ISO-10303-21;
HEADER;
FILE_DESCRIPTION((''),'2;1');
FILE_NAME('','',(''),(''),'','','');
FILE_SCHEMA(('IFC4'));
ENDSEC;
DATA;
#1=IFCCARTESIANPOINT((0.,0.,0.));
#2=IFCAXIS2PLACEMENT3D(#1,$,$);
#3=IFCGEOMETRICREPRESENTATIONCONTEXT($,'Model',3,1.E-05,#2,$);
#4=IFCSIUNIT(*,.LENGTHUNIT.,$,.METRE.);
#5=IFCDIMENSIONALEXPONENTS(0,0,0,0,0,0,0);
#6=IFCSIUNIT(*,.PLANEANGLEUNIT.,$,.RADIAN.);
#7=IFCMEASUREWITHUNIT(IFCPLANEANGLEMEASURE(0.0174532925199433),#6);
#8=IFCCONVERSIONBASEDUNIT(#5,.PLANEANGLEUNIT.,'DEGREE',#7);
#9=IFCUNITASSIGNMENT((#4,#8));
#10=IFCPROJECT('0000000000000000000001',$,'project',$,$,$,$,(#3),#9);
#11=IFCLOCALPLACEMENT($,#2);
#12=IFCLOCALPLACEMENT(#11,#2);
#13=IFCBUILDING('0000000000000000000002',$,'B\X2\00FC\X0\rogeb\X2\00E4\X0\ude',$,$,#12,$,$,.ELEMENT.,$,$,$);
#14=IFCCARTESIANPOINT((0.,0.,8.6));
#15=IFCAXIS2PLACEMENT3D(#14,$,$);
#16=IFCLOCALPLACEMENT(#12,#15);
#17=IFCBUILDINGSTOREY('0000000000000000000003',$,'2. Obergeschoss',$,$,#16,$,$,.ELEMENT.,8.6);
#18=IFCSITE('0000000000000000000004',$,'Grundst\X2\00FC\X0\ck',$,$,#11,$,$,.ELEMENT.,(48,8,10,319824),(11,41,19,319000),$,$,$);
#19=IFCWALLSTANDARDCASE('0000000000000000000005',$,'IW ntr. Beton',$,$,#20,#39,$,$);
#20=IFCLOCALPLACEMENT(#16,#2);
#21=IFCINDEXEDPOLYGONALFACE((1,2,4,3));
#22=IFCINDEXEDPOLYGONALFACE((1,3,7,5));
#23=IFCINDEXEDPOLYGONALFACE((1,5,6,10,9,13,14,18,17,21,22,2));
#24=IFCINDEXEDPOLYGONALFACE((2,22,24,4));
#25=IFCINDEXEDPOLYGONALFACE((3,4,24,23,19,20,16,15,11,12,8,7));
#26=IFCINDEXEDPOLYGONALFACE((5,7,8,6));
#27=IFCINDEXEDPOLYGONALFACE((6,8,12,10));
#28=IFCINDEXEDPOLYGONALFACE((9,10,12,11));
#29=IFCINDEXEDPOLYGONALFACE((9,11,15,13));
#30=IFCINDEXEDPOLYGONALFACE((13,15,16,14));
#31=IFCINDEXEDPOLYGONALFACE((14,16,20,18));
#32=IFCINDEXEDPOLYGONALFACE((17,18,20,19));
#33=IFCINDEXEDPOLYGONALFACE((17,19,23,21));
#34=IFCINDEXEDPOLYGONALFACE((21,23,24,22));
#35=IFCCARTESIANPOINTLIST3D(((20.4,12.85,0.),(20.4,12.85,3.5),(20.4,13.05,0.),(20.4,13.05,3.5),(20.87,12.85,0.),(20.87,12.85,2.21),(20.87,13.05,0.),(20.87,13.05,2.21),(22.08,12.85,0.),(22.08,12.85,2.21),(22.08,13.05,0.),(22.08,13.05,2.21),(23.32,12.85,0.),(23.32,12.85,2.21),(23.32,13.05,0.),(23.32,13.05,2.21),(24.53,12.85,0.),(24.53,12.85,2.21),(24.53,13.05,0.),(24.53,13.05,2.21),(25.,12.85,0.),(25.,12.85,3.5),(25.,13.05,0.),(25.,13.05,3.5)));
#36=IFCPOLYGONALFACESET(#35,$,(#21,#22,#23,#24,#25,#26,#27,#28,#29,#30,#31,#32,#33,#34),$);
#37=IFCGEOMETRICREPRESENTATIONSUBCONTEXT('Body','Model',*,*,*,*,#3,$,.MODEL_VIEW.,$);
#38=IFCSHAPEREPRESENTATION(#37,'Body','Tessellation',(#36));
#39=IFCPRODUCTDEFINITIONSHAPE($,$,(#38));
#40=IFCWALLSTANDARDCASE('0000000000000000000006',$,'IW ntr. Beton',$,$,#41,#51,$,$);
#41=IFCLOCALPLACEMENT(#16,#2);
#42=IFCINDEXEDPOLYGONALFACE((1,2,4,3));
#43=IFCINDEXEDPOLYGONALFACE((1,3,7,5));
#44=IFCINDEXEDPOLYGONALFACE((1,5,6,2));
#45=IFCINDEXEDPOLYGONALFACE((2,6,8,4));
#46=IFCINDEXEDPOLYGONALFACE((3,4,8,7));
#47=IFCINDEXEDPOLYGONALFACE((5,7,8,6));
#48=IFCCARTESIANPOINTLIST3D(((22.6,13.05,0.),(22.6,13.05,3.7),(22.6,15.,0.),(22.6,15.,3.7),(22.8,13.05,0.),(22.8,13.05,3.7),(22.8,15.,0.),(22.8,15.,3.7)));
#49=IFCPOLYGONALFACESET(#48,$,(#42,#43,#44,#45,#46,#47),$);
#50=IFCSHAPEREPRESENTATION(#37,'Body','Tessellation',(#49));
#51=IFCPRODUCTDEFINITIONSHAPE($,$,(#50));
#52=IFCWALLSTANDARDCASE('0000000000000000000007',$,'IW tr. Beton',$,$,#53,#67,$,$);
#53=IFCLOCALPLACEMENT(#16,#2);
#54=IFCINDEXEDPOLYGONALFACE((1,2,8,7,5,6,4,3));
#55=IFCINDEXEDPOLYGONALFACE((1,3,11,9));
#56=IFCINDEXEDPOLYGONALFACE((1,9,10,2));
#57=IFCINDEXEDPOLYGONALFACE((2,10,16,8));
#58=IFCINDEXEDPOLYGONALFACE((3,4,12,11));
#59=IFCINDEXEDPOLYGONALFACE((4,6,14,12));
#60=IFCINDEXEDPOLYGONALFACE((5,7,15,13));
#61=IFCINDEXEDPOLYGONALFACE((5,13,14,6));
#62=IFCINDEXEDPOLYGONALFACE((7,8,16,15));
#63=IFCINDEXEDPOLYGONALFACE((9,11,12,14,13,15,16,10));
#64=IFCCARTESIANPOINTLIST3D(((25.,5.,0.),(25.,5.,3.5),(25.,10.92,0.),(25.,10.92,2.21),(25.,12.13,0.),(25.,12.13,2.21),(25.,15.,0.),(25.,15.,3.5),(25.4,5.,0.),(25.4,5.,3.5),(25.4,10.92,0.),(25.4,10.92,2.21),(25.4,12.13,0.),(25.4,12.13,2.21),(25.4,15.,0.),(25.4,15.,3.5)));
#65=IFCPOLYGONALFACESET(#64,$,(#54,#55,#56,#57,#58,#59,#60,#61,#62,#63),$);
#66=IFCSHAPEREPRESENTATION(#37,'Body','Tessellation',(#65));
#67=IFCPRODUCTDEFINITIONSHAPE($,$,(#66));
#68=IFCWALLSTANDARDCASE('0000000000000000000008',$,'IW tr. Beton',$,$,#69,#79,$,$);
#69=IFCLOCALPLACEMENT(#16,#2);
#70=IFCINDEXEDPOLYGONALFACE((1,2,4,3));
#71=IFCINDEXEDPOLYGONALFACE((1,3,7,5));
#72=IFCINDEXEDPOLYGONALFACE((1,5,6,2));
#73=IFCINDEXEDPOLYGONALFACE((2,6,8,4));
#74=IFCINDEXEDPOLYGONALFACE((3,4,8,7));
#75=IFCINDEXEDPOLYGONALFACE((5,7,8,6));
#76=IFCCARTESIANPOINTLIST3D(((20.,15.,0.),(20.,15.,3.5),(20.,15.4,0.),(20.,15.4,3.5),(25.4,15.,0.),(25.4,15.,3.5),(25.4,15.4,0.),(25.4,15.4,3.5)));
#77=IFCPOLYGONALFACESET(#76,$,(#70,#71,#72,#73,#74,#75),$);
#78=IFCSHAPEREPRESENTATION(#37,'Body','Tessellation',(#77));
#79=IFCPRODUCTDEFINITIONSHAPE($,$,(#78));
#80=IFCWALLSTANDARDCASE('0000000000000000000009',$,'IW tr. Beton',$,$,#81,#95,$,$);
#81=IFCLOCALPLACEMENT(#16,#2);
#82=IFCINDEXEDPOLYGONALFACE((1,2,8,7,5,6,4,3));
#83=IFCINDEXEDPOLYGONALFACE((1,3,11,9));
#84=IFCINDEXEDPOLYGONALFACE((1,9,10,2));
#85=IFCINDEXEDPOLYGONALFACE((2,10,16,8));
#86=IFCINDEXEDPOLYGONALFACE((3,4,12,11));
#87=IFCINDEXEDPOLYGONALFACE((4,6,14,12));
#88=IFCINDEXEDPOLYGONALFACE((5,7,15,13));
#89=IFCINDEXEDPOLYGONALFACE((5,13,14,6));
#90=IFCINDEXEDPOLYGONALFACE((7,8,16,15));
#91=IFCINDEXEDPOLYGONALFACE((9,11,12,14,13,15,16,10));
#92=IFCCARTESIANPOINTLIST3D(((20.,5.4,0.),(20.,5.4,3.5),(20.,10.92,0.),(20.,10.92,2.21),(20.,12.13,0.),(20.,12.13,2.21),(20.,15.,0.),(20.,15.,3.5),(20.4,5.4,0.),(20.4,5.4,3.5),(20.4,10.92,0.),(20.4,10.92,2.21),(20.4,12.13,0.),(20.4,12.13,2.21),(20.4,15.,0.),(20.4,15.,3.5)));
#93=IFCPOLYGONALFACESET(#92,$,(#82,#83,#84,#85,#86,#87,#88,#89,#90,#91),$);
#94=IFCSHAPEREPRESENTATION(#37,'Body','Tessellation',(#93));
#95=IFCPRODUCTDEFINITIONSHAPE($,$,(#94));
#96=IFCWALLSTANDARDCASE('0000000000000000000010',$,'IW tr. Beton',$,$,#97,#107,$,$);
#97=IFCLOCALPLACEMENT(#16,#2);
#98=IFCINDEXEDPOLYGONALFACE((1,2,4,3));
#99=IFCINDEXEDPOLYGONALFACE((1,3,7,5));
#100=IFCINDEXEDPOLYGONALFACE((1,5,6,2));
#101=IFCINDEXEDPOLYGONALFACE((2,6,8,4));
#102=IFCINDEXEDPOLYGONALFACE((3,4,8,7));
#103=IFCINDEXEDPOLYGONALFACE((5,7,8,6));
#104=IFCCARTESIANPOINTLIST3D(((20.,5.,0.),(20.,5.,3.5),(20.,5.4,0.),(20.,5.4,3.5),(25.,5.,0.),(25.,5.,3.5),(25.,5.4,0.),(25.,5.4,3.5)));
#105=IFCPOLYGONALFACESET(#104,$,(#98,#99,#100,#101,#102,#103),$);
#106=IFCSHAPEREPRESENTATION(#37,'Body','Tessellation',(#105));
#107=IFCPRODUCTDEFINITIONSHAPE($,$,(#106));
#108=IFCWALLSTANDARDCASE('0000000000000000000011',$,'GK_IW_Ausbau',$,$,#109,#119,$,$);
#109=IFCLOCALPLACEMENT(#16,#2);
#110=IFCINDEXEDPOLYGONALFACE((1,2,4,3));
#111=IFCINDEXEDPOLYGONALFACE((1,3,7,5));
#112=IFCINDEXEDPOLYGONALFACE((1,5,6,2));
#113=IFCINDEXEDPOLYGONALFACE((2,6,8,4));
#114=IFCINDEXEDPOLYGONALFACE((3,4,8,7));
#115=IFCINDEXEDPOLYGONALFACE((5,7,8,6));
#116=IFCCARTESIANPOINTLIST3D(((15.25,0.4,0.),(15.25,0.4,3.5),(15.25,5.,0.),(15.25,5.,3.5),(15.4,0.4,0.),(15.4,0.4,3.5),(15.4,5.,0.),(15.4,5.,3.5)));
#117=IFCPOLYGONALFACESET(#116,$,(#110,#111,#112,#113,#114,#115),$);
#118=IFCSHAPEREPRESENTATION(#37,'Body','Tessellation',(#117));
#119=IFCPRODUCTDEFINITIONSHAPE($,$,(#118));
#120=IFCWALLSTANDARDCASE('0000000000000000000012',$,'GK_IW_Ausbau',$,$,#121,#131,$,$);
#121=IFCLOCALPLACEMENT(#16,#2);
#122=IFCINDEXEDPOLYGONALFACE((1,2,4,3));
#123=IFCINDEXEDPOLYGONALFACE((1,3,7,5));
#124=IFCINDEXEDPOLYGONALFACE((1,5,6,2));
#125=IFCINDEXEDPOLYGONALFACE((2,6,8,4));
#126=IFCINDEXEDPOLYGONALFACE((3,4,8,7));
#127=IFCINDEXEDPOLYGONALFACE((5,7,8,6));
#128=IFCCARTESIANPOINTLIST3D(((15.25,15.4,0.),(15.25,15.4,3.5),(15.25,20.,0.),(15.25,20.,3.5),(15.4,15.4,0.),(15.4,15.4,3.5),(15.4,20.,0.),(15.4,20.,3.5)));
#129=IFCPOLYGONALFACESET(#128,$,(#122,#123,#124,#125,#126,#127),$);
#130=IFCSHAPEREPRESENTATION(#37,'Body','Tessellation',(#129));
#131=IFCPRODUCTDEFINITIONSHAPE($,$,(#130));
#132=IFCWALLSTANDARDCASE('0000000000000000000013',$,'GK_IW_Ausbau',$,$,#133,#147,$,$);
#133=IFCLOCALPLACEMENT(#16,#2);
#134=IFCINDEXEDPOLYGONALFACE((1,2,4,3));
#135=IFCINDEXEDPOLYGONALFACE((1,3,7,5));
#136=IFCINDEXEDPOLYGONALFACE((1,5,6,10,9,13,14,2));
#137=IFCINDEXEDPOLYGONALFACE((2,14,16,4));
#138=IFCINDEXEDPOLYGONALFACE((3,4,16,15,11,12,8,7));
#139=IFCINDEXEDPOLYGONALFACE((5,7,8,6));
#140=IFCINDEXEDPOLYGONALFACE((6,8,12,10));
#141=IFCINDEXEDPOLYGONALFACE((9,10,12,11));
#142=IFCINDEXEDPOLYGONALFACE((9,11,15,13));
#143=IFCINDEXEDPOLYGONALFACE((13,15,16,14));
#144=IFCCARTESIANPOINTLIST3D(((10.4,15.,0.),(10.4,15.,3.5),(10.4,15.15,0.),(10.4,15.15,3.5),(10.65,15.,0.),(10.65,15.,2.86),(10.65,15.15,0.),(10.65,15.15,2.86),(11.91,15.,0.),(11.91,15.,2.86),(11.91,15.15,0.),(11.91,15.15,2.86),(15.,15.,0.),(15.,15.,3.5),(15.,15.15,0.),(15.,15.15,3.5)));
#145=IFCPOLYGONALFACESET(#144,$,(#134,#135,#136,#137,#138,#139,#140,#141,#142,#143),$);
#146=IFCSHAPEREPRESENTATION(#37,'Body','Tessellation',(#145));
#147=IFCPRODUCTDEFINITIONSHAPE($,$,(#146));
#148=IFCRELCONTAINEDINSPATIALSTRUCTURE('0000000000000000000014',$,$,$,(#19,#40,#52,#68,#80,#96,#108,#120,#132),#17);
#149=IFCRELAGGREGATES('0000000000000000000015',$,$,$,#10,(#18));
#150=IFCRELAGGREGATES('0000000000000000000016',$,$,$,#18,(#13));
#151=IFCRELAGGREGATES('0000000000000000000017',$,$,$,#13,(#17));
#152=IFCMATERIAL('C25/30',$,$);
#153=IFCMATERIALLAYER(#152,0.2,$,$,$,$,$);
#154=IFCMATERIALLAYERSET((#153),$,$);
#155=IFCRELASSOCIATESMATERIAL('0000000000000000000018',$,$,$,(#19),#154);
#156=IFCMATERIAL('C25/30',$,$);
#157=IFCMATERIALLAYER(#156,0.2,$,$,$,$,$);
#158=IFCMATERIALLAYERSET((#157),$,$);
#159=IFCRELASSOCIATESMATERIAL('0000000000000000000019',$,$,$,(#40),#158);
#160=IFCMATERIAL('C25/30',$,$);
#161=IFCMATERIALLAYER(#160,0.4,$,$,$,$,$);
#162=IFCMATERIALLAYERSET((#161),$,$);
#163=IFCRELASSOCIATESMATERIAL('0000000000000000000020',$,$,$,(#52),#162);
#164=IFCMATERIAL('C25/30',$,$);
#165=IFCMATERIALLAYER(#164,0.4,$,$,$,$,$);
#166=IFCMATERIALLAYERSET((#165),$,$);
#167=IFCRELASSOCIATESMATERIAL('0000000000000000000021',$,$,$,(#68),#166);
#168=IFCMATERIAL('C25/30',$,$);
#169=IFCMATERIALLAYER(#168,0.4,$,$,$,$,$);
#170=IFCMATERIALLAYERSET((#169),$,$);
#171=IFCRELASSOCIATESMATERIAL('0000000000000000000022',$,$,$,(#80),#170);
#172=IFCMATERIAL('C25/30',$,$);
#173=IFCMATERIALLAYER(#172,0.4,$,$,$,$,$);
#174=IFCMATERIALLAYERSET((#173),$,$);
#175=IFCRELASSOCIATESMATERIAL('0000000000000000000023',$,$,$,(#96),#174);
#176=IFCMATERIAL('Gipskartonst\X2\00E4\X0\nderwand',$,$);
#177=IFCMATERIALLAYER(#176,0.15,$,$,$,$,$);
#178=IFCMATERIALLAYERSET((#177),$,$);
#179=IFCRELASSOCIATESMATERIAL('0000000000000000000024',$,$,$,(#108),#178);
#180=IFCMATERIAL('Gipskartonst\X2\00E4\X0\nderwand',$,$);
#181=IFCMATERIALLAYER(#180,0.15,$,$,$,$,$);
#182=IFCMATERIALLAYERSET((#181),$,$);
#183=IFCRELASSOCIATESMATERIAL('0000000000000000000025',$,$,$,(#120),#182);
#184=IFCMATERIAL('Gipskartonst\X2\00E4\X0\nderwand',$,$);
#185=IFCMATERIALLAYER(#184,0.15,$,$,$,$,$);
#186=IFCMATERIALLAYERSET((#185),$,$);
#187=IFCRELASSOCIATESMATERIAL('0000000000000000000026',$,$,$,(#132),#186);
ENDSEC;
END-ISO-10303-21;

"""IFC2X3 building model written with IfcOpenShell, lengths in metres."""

from ifc_helpers import new_model, entity, si_unit, converted_unit, frame, frame_2d, origin, origin_with_axes, place, context, subcontext, project, spatial, polyline, rectangle, outline, extrude, material, layer, layer_set, layer_usage, element, save


model = new_model("IFC2X3")

# Units and contexts
model_context = context("Model", 3, precision=1e-05, world=origin())
body_context = subcontext(model_context, "Body", "Model", "MODEL_VIEW")
ifc_project = project(units=[si_unit("LENGTHUNIT", "METRE"), converted_unit("PLANEANGLEUNIT", "DEGREE", entity("IfcPlaneAngleMeasure", 0.0174532925199433), si_unit("PLANEANGLEUNIT", "RADIAN"), dimensions=[0, 0, 0, 0, 0, 0, 0])], contexts=[model_context])

# Site, building, storey
site_placement = place(None, origin())
site = spatial("IfcSite", under=ifc_project, at=site_placement, Name="Grundstück", CompositionType="ELEMENT", RefLatitude=(48, 8, 10, 319824), RefLongitude=(11, 41, 19, 319000))
building_placement = place(site_placement, origin())
building = spatial("IfcBuilding", under=site, at=building_placement, Name="Bürogebäude", CompositionType="ELEMENT")
storey_placement = place(building_placement, frame((0.0, 0.0, 8.6)))
storey = spatial("IfcBuildingStorey", under=building, at=storey_placement, Name="2. Obergeschoss", CompositionType="ELEMENT", Elevation=8.6)

# Wall, openings
ifc_material_1 = material(Name="C25/30")
ifc_layer_1 = layer(ifc_material_1, 0.2)
ifc_layer_set_1 = layer_set([ifc_layer_1])
ifc_layer_usage_1 = layer_usage(ifc_layer_set_1, "AXIS2", "POSITIVE", -0.2)
wall_1_placement = place(storey_placement, frame((25.0, 13.05, 0.0), z_axis=(0.0, 0.0, 1.0), x_axis=(-1.0, 0.0, 0.0)))
wall_1 = element("IfcWallStandardCase", 1, at=wall_1_placement, inside=storey, material=ifc_layer_usage_1, Name="IW ntr. Beton", context=body_context, shape_type="SweptSolid", body=[
    extrude(rectangle(XDim=4.6, YDim=0.2, at=frame_2d((2.3, 0.1), x_axis=(1.0, 0.0))), origin_with_axes(), (0.0, 0.0, 1.0), 3.5),
])
opening_1_placement = place(wall_1_placement, frame((1.68, 0.2, 0.0), z_axis=(0.0, -1.0, 0.0), x_axis=(0.0, 0.0, 1.0)))
element("IfcOpeningElement", 2, at=opening_1_placement, cuts=wall_1, ObjectType="Opening", context=body_context, shape_type="SweptSolid", body=[
    extrude(outline(polyline([(0.0, 1.21), (2.21, 1.21), (2.21, 0.0), (0.0, 0.0), (0.0, 1.21)])), origin_with_axes(), (0.0, 0.0, 1.0), 0.2),
])
opening_2_placement = place(wall_1_placement, frame((4.13, 0.2, 0.0), z_axis=(0.0, -1.0, 0.0), x_axis=(0.0, 0.0, 1.0)))
element("IfcOpeningElement", 3, at=opening_2_placement, cuts=wall_1, ObjectType="Opening", context=body_context, shape_type="SweptSolid", body=[
    extrude(outline(polyline([(0.0, 1.21), (2.21, 1.21), (2.21, 0.0), (0.0, 0.0), (0.0, 1.21)])), origin_with_axes(), (0.0, 0.0, 1.0), 0.2),
])

# Wall
ifc_material_2 = material(Name="C25/30")
ifc_layer_2 = layer(ifc_material_2, 0.2)
ifc_layer_set_2 = layer_set([ifc_layer_2])
ifc_layer_usage_2 = layer_usage(ifc_layer_set_2, "AXIS2", "POSITIVE", -0.2)
wall_2_placement = place(storey_placement, frame((22.6, 15.0, 0.0), z_axis=(0.0, 0.0, 1.0), x_axis=(0.0, -1.0, 0.0)))
element("IfcWallStandardCase", 4, at=wall_2_placement, inside=storey, material=ifc_layer_usage_2, Name="IW ntr. Beton", context=body_context, shape_type="SweptSolid", body=[
    extrude(rectangle(XDim=1.95, YDim=0.2, at=frame_2d((0.975, 0.1), x_axis=(1.0, 0.0))), origin_with_axes(), (0.0, 0.0, 1.0), 3.7),
])

# Wall, opening
ifc_material_3 = material(Name="C25/30")
ifc_layer_3 = layer(ifc_material_3, 0.4)
ifc_layer_set_3 = layer_set([ifc_layer_3])
ifc_layer_usage_3 = layer_usage(ifc_layer_set_3, "AXIS2", "POSITIVE", -0.2)
wall_3_placement = place(storey_placement, frame((25.0, 15.0, 0.0), z_axis=(0.0, 0.0, 1.0), x_axis=(0.0, -1.0, 0.0)))
wall_3 = element("IfcWallStandardCase", 5, at=wall_3_placement, inside=storey, material=ifc_layer_usage_3, Name="IW tr. Beton", context=body_context, shape_type="SweptSolid", body=[
    extrude(rectangle(XDim=10.0, YDim=0.4, at=frame_2d((5.0, 0.2), x_axis=(1.0, 0.0))), origin_with_axes(), (0.0, 0.0, 1.0), 3.5),
])
opening_3_placement = place(wall_3_placement, frame((2.87, 0.0, 0.0), z_axis=(0.0, 1.0, 0.0), x_axis=(0.0, 0.0, 1.0)))
element("IfcOpeningElement", 6, at=opening_3_placement, cuts=wall_3, ObjectType="Opening", context=body_context, shape_type="SweptSolid", body=[
    extrude(outline(polyline([(0.0, 1.21), (2.21, 1.21), (2.21, 0.0), (0.0, 0.0), (0.0, 1.21)])), origin_with_axes(), (0.0, 0.0, 1.0), 0.4),
])

# Wall
ifc_material_4 = material(Name="C25/30")
ifc_layer_4 = layer(ifc_material_4, 0.4)
ifc_layer_set_4 = layer_set([ifc_layer_4])
ifc_layer_usage_4 = layer_usage(ifc_layer_set_4, "AXIS2", "POSITIVE", -0.2)
wall_4_placement = place(storey_placement, frame((20.0, 15.0, 0.0)))
element("IfcWallStandardCase", 7, at=wall_4_placement, inside=storey, material=ifc_layer_usage_4, Name="IW tr. Beton", context=body_context, shape_type="SweptSolid", body=[
    extrude(rectangle(XDim=5.4, YDim=0.4, at=frame_2d((2.7, 0.2), x_axis=(1.0, 0.0))), origin_with_axes(), (0.0, 0.0, 1.0), 3.5),
])

# Wall, opening
ifc_material_5 = material(Name="C25/30")
ifc_layer_5 = layer(ifc_material_5, 0.4)
ifc_layer_set_5 = layer_set([ifc_layer_5])
ifc_layer_usage_5 = layer_usage(ifc_layer_set_5, "AXIS2", "POSITIVE", -0.2)
wall_5_placement = place(storey_placement, frame((20.4, 5.4, 0.0), z_axis=(0.0, 0.0, 1.0), x_axis=(0.0, 1.0, 0.0)))
wall_5 = element("IfcWallStandardCase", 8, at=wall_5_placement, inside=storey, material=ifc_layer_usage_5, Name="IW tr. Beton", context=body_context, shape_type="SweptSolid", body=[
    extrude(rectangle(XDim=9.6, YDim=0.4, at=frame_2d((4.8, 0.2), x_axis=(1.0, 0.0))), origin_with_axes(), (0.0, 0.0, 1.0), 3.5),
])
opening_4_placement = place(wall_5_placement, frame((5.52, 0.0, 0.0), z_axis=(0.0, 1.0, 0.0), x_axis=(0.0, 0.0, 1.0)))
element("IfcOpeningElement", 9, at=opening_4_placement, cuts=wall_5, ObjectType="Opening", context=body_context, shape_type="SweptSolid", body=[
    extrude(outline(polyline([(0.0, 1.21), (2.21, 1.21), (2.21, 0.0), (0.0, 0.0), (0.0, 1.21)])), origin_with_axes(), (0.0, 0.0, 1.0), 0.4),
])

# Walls
ifc_material_6 = material(Name="C25/30")
ifc_layer_6 = layer(ifc_material_6, 0.4)
ifc_layer_set_6 = layer_set([ifc_layer_6])
ifc_layer_usage_6 = layer_usage(ifc_layer_set_6, "AXIS2", "POSITIVE", -0.2)
wall_6_placement = place(storey_placement, frame((25.0, 5.4, 0.0), z_axis=(0.0, 0.0, 1.0), x_axis=(-1.0, 0.0, 0.0)))
element("IfcWallStandardCase", 10, at=wall_6_placement, inside=storey, material=ifc_layer_usage_6, Name="IW tr. Beton", context=body_context, shape_type="SweptSolid", body=[
    extrude(rectangle(XDim=5.0, YDim=0.4, at=frame_2d((2.5, 0.2), x_axis=(1.0, 0.0))), origin_with_axes(), (0.0, 0.0, 1.0), 3.5),
])
ifc_material_7 = material(Name="Gipskartonständerwand")
ifc_layer_7 = layer(ifc_material_7, 0.15)
ifc_layer_set_7 = layer_set([ifc_layer_7])
ifc_layer_usage_7 = layer_usage(ifc_layer_set_7, "AXIS2", "POSITIVE", -0.15)
wall_7_placement = place(storey_placement, frame((15.25, 5.0, 0.0), z_axis=(0.0, 0.0, 1.0), x_axis=(0.0, -1.0, 0.0)))
element("IfcWallStandardCase", 11, at=wall_7_placement, inside=storey, material=ifc_layer_usage_7, Name="GK_IW_Ausbau", context=body_context, shape_type="SweptSolid", body=[
    extrude(rectangle(XDim=4.6, YDim=0.15, at=frame_2d((2.3, 0.075), x_axis=(1.0, 0.0))), origin_with_axes(), (0.0, 0.0, 1.0), 3.5),
])
ifc_material_8 = material(Name="Gipskartonständerwand")
ifc_layer_8 = layer(ifc_material_8, 0.15)
ifc_layer_set_8 = layer_set([ifc_layer_8])
ifc_layer_usage_8 = layer_usage(ifc_layer_set_8, "AXIS2", "POSITIVE", -0.15)
wall_8_placement = place(storey_placement, frame((15.25, 20.0, 0.0), z_axis=(0.0, 0.0, 1.0), x_axis=(0.0, -1.0, 0.0)))
element("IfcWallStandardCase", 12, at=wall_8_placement, inside=storey, material=ifc_layer_usage_8, Name="GK_IW_Ausbau", context=body_context, shape_type="SweptSolid", body=[
    extrude(rectangle(XDim=4.6, YDim=0.15, at=frame_2d((2.3, 0.075), x_axis=(1.0, 0.0))), origin_with_axes(), (0.0, 0.0, 1.0), 3.5),
])

# Wall, opening
ifc_material_9 = material(Name="Gipskartonständerwand")
ifc_layer_9 = layer(ifc_material_9, 0.15)
ifc_layer_set_9 = layer_set([ifc_layer_9])
ifc_layer_usage_9 = layer_usage(ifc_layer_set_9, "AXIS2", "POSITIVE", -0.15)
wall_9_placement = place(storey_placement, frame((15.0, 15.15, 0.0), z_axis=(0.0, 0.0, 1.0), x_axis=(-1.0, 0.0, 0.0)))
wall_9 = element("IfcWallStandardCase", 13, at=wall_9_placement, inside=storey, material=ifc_layer_usage_9, Name="GK_IW_Ausbau", context=body_context, shape_type="SweptSolid", body=[
    extrude(rectangle(XDim=4.6, YDim=0.15, at=frame_2d((2.3, 0.075), x_axis=(1.0, 0.0))), origin_with_axes(), (0.0, 0.0, 1.0), 3.5),
])
opening_5_placement = place(wall_9_placement, frame((4.35, 0.15, 0.0), z_axis=(0.0, -1.0, 0.0), x_axis=(0.0, 0.0, 1.0)))
element("IfcOpeningElement", 14, at=opening_5_placement, cuts=wall_9, ObjectType="Opening", context=body_context, shape_type="SweptSolid", body=[
    extrude(outline(polyline([(0.0, 1.26), (2.86, 1.26), (2.86, 0.0), (0.0, 0.0), (0.0, 1.26)])), origin_with_axes(), (0.0, 0.0, 1.0), 0.15),
])

save(model, "model.ifc")
